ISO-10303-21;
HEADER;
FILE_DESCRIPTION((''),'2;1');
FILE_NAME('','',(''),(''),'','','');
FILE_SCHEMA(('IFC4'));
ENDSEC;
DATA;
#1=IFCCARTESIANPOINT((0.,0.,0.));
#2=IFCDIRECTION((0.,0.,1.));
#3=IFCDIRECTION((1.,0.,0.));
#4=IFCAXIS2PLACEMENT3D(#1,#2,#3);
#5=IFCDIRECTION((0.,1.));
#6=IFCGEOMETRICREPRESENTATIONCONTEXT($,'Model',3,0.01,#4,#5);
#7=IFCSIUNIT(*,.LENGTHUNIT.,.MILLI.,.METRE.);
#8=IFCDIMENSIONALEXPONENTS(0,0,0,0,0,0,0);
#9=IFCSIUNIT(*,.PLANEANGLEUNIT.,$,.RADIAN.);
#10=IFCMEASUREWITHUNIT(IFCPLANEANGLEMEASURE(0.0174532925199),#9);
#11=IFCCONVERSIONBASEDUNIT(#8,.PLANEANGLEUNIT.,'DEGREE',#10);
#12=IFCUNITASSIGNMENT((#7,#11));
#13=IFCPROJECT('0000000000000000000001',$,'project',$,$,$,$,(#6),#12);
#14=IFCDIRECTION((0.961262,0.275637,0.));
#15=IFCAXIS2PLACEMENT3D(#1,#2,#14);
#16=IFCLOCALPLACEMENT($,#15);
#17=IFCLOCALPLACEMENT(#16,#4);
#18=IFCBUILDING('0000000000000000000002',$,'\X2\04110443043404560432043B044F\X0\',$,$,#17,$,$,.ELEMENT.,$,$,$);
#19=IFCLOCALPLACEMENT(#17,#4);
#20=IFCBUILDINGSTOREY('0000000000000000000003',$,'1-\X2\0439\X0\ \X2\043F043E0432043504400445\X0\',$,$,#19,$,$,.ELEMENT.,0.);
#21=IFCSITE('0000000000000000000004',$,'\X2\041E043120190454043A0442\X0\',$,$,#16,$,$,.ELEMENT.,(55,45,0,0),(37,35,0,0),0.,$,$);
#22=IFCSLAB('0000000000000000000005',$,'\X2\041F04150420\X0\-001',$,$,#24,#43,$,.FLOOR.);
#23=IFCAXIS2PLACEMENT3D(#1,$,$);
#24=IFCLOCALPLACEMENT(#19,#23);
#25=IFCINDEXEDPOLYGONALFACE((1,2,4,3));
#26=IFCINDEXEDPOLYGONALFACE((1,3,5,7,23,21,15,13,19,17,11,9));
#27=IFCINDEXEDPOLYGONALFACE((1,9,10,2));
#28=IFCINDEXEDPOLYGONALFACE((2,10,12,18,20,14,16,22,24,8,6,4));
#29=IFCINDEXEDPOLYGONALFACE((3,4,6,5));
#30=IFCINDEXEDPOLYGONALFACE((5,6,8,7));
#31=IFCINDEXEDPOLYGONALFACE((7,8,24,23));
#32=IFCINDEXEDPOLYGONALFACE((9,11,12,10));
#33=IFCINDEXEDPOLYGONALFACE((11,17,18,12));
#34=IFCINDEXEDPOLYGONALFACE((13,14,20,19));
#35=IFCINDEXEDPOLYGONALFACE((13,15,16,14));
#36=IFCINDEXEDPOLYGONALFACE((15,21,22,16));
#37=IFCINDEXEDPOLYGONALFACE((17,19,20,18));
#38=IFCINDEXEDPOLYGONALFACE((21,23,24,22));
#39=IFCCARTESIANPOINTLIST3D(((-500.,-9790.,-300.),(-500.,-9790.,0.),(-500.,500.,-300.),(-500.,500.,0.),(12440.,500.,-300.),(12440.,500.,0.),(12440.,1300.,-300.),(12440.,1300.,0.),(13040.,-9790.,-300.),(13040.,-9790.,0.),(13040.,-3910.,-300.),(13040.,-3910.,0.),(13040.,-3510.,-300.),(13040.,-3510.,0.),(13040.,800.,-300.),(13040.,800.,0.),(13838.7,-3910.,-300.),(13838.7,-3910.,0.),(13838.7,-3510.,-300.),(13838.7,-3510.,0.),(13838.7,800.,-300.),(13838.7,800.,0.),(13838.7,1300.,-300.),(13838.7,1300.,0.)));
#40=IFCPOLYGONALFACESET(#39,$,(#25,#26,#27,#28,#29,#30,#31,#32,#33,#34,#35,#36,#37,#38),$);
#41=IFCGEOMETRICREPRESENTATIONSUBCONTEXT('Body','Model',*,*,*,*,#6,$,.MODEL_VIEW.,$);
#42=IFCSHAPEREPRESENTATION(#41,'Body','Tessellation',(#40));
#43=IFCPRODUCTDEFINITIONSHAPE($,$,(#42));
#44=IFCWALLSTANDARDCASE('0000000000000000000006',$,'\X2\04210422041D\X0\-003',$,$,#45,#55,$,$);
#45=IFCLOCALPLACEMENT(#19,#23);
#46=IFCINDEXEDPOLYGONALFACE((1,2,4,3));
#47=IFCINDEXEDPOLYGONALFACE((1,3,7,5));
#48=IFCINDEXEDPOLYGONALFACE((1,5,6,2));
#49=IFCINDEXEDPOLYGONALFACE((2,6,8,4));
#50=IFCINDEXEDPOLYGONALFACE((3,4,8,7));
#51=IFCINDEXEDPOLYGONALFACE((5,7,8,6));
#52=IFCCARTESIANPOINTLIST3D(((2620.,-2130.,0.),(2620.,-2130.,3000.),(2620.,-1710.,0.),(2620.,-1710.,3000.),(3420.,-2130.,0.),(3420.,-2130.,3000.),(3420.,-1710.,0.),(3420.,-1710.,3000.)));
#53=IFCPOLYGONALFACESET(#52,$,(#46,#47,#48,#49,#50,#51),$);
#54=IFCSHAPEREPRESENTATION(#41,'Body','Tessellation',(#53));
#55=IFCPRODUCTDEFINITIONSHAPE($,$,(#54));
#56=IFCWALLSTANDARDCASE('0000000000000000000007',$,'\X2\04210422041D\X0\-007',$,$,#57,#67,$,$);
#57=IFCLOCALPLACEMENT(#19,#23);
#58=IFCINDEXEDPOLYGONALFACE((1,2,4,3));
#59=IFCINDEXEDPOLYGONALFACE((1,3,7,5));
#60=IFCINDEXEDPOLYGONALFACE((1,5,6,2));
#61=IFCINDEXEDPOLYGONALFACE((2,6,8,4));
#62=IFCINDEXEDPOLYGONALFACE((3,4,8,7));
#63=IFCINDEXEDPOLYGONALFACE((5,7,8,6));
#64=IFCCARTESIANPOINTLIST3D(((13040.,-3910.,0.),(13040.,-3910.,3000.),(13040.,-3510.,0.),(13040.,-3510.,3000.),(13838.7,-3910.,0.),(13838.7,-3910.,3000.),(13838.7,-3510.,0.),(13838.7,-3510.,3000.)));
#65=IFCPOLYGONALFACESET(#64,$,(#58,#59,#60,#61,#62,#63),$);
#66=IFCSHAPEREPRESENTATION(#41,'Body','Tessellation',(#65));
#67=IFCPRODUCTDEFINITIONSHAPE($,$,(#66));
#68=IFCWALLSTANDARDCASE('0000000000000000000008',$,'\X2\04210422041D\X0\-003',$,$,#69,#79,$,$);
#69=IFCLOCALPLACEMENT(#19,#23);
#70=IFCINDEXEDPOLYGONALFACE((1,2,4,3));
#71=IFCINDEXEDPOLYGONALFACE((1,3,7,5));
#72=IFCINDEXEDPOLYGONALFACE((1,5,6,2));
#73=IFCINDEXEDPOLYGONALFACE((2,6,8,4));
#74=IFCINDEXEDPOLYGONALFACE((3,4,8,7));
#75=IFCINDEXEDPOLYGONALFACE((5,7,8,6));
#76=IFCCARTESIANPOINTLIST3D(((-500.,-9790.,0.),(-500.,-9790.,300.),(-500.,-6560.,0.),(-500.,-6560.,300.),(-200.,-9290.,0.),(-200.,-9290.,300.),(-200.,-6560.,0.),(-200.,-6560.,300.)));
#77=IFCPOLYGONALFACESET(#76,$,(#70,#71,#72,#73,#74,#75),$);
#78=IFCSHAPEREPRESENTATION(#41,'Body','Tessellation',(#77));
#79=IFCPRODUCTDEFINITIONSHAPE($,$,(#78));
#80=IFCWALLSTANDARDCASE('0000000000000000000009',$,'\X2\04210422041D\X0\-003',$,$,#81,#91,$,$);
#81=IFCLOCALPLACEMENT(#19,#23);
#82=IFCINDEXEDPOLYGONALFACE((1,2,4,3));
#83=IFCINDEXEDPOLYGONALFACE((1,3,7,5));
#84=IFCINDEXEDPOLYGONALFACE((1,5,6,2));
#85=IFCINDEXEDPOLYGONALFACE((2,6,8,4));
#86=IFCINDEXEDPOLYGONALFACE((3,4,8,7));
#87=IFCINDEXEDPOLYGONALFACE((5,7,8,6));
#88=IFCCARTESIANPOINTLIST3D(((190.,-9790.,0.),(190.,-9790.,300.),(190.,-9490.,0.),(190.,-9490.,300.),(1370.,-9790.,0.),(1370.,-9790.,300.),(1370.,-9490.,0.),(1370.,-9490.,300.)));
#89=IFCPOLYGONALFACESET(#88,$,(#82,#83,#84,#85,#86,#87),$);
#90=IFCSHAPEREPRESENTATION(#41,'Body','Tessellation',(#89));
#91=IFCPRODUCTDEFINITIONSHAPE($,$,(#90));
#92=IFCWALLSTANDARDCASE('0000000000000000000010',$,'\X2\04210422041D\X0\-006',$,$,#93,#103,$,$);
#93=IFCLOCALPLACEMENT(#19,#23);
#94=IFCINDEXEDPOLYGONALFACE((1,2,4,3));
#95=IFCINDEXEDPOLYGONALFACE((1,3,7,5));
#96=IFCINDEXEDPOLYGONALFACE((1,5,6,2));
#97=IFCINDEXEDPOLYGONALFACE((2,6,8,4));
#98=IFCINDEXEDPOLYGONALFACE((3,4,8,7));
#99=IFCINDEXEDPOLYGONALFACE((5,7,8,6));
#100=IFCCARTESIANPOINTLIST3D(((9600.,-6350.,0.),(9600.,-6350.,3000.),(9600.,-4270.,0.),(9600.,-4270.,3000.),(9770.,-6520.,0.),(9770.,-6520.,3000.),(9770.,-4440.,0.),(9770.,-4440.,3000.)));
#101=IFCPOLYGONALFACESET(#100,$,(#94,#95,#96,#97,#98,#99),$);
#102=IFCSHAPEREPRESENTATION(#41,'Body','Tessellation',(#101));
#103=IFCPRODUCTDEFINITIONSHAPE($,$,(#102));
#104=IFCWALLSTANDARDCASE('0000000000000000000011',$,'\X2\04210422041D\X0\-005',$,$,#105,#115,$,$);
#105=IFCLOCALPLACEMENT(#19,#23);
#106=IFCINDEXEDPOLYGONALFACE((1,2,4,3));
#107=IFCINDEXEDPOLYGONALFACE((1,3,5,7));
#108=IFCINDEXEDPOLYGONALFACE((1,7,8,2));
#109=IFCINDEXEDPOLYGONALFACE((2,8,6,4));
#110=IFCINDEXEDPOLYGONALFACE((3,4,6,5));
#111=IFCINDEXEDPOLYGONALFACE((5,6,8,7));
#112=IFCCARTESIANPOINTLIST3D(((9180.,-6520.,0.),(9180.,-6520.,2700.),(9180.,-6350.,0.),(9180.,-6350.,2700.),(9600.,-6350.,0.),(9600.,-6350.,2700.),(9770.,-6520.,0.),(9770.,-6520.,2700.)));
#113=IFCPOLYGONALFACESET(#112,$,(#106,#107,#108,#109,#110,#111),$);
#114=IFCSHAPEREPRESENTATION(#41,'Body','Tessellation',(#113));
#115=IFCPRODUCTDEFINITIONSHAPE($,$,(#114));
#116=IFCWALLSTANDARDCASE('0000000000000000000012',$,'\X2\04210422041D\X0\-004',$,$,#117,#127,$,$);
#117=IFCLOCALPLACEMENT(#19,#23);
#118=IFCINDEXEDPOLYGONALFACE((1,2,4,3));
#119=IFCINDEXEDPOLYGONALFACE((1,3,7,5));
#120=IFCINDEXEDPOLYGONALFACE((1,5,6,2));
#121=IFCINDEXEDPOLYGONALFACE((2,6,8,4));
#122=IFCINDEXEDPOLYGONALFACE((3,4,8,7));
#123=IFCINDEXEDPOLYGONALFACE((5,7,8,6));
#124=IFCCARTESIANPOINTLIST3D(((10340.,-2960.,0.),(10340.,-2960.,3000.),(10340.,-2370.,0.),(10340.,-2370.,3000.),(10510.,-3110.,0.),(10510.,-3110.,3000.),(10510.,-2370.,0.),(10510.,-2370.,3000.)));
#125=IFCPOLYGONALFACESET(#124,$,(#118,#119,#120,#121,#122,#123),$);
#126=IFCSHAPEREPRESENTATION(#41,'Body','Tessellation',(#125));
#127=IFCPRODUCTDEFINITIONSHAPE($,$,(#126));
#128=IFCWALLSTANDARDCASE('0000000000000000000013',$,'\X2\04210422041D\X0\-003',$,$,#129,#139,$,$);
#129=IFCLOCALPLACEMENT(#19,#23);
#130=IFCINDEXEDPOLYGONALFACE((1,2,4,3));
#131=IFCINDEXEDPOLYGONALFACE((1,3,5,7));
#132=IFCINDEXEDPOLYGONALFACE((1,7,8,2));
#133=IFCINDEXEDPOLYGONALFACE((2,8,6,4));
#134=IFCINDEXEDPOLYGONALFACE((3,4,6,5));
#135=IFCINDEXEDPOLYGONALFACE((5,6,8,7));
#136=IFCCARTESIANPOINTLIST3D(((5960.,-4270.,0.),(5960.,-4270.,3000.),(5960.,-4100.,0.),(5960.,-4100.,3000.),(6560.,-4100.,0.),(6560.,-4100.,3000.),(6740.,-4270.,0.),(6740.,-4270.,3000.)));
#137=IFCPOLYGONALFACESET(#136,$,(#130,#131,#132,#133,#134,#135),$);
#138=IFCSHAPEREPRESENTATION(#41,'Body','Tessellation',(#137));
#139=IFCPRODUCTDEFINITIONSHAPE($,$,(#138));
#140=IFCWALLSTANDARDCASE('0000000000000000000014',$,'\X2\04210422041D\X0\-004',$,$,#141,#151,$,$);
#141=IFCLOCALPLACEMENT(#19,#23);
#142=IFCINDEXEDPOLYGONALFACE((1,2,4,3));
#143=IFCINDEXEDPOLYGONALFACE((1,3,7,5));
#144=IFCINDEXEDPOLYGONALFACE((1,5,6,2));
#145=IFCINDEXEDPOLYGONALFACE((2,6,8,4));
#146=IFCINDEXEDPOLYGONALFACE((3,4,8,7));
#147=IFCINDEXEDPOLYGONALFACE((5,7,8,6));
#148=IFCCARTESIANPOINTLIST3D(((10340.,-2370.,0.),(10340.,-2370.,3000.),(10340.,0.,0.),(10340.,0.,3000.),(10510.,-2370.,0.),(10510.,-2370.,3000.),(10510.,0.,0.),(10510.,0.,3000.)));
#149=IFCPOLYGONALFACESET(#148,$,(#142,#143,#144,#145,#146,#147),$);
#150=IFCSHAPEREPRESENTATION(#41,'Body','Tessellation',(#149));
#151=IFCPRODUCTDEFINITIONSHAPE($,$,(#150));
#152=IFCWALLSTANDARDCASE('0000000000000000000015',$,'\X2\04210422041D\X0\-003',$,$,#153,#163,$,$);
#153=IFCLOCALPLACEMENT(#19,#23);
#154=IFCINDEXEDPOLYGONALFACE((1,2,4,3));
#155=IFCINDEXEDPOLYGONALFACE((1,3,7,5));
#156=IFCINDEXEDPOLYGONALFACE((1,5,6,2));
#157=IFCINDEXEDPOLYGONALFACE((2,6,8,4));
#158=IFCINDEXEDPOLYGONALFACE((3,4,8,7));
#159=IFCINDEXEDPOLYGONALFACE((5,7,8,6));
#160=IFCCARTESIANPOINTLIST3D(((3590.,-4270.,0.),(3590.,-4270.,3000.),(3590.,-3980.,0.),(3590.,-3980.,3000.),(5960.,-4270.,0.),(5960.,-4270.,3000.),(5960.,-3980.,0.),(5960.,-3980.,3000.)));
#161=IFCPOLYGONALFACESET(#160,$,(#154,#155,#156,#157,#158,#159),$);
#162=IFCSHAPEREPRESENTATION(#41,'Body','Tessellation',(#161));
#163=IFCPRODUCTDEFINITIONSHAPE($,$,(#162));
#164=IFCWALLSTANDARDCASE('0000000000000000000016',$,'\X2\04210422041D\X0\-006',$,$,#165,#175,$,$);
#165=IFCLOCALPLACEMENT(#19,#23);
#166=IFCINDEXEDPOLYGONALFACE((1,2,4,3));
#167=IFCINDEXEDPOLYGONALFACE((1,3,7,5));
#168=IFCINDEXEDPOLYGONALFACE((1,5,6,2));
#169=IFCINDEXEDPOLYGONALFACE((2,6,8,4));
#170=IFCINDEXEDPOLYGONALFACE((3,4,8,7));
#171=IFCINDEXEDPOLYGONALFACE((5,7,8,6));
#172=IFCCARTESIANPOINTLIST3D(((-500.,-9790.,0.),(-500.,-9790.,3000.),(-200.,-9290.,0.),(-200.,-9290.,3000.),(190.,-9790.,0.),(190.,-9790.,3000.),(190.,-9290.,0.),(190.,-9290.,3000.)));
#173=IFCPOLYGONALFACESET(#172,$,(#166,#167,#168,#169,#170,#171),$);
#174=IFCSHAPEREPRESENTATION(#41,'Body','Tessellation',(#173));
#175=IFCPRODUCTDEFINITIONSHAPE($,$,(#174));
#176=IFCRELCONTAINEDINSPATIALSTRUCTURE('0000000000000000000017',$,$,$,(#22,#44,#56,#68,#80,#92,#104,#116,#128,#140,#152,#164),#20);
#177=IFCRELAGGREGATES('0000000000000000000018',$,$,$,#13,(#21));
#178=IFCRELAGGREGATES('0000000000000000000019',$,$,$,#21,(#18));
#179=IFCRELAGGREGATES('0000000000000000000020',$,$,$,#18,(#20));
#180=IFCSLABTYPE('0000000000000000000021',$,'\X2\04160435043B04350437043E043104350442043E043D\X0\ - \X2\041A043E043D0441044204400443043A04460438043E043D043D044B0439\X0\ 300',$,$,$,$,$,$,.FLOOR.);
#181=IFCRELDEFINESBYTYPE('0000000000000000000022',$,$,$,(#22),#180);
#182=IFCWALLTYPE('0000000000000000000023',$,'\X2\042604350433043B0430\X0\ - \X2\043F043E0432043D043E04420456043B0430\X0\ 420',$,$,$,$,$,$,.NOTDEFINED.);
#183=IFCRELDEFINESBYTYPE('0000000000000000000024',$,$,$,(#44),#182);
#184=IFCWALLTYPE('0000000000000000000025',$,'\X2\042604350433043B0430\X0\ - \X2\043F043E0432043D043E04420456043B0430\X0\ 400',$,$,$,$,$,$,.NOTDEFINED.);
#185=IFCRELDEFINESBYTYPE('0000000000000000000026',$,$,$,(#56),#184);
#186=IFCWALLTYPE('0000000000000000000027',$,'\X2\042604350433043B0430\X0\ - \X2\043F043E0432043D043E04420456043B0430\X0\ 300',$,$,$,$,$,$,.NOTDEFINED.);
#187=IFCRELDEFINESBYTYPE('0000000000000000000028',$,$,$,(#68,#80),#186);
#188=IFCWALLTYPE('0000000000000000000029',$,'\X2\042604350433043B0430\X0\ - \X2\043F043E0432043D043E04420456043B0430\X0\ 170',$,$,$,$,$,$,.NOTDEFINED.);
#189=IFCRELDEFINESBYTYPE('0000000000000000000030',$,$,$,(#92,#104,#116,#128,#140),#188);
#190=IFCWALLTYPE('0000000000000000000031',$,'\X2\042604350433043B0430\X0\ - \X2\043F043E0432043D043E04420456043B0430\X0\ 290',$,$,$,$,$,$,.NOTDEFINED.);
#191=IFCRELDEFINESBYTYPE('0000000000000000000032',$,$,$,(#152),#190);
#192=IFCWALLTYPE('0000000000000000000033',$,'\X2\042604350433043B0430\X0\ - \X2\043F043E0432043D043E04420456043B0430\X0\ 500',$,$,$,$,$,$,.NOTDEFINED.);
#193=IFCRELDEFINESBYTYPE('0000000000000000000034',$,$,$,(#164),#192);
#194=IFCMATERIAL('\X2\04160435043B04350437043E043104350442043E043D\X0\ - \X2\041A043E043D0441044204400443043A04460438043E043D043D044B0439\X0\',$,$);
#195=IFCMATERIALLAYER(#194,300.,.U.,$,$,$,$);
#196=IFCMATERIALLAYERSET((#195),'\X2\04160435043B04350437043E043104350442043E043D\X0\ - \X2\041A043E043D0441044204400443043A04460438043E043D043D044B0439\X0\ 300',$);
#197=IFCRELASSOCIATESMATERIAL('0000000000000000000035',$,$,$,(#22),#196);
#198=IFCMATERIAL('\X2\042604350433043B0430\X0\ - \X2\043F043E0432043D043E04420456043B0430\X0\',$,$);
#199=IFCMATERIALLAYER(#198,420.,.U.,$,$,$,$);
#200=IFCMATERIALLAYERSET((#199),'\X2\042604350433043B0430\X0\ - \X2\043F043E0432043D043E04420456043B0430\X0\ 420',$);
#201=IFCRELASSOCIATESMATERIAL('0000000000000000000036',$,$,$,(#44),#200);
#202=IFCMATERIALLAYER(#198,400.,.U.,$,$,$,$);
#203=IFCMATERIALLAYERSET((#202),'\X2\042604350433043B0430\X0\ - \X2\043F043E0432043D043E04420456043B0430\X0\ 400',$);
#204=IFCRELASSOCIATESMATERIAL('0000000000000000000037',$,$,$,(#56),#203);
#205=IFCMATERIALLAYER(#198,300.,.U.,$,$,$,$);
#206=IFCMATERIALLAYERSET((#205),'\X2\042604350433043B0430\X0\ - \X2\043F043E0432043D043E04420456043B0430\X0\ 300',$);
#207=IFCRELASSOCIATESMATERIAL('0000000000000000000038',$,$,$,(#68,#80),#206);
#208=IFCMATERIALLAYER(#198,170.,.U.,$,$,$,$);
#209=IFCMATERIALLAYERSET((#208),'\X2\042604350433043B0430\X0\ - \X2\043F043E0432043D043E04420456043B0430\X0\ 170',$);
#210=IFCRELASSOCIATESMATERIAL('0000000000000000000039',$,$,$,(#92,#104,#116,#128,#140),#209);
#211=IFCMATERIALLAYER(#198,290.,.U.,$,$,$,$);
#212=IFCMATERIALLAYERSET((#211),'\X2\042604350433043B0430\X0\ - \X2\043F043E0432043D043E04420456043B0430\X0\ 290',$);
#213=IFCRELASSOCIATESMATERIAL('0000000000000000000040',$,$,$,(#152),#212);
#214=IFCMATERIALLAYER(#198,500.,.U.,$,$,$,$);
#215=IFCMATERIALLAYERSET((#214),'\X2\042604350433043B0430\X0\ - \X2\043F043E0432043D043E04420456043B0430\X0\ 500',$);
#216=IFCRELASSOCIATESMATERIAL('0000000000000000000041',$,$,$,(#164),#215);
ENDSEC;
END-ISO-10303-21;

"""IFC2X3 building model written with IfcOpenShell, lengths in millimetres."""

from ifc_helpers import new_model, entity, si_unit, converted_unit, direction, frame, origin_with_axes, place, context, subcontext, project, spatial, polyline, outline, extrude, material, layer, layer_set, layer_usage, type_object, element, save


model = new_model("IFC2X3")

# Units and contexts
model_context = context("Model", 3, precision=0.01, world=origin_with_axes(), true_north=direction((0.0, 1.0)))
body_context = subcontext(model_context, "Body", "Model", "MODEL_VIEW")
ifc_project = project(units=[si_unit("LENGTHUNIT", "METRE", prefix="MILLI"), converted_unit("PLANEANGLEUNIT", "DEGREE", entity("IfcPlaneAngleMeasure", 0.0174532925199), si_unit("PLANEANGLEUNIT", "RADIAN"), dimensions=[0, 0, 0, 0, 0, 0, 0])], contexts=[model_context])

# Site, building, storey
site_placement = place(None, frame((0.0, 0.0, 0.0), z_axis=(0.0, 0.0, 1.0), x_axis=(0.961262, 0.275637, 0.0)))
site = spatial("IfcSite", under=ifc_project, at=site_placement, Name="Об’єкт", CompositionType="ELEMENT", RefLatitude=(55, 45, 0, 0), RefLongitude=(37, 35, 0, 0), RefElevation=0.0)
building_placement = place(site_placement, origin_with_axes())
building = spatial("IfcBuilding", under=site, at=building_placement, Name="Будівля", CompositionType="ELEMENT")
storey_placement = place(building_placement, origin_with_axes())
storey = spatial("IfcBuildingStorey", under=building, at=storey_placement, Name="1-й поверх", CompositionType="ELEMENT", Elevation=0.0)

# Slab
ifc_material_1 = material(Name="Железобетон - Конструкционный")
ifc_layer_1 = layer(ifc_material_1, 300.0, ventilated="UNKNOWN")
ifc_layer_set_1 = layer_set([ifc_layer_1], Name="Железобетон - Конструкционный 300")
ifc_layer_usage_1 = layer_usage(ifc_layer_set_1, "AXIS3", "NEGATIVE", 300.0)
slab_type = type_object("IfcSlabType", Name="Железобетон - Конструкционный 300", PredefinedType="FLOOR")
slab_placement = place(storey_placement, frame((-500.0, 500.0, 0.0), z_axis=(0.0, 0.0, 1.0), x_axis=(1.0, 0.0, 0.0)))
element("IfcSlab", 1, at=slab_placement, inside=storey, type_object=slab_type, material=ifc_layer_usage_1, Name="ПЕР-001", PredefinedType="FLOOR", context=body_context, shape_type="SweptSolid", body=[
    extrude(outline(polyline([(0.0, 0.0), (0.0, -10290.0), (13540.0, -10290.0), (13540.0, -4410.0), (14338.7, -4410.0), (14338.7, -4010.0), (13540.0, -4010.0), (13540.0, 300.0), (14338.7, 300.0), (14338.7, 800.0), (12940.0, 800.0), (12940.0, 0.0), (0.0, 0.0)])), frame((0.0, 0.0, -300.0), z_axis=(0.0, 0.0, 1.0), x_axis=(1.0, 0.0, 0.0)), (0.0, 0.0, 1.0), 300.0),
])

# Walls
ifc_material_2 = material(Name="Цегла - повнотіла")
ifc_layer_2 = layer(ifc_material_2, 420.0, ventilated="UNKNOWN")
ifc_layer_set_2 = layer_set([ifc_layer_2], Name="Цегла - повнотіла 420")
ifc_layer_usage_2 = layer_usage(ifc_layer_set_2, "AXIS2", "POSITIVE", 0.0)
wall_type_1 = type_object("IfcWallType", Name="Цегла - повнотіла 420", PredefinedType="NOTDEFINED")
wall_1_placement = place(storey_placement, frame((2620.0, -2130.0, 0.0), z_axis=(0.0, 0.0, 1.0), x_axis=(1.0, 0.0, 0.0)))
element("IfcWallStandardCase", 2, at=wall_1_placement, inside=storey, type_object=wall_type_1, material=ifc_layer_usage_2, Name="СТН-003", context=body_context, shape_type="SweptSolid", body=[
    extrude(outline(polyline([(0.0, 0.0), (800.0, 0.0), (800.0, 420.0), (0.0, 420.0), (0.0, 0.0)])), origin_with_axes(), (0.0, 0.0, 1.0), 3000.0),
])
ifc_layer_3 = layer(ifc_material_2, 400.0, ventilated="UNKNOWN")
ifc_layer_set_3 = layer_set([ifc_layer_3], Name="Цегла - повнотіла 400")
ifc_layer_usage_3 = layer_usage(ifc_layer_set_3, "AXIS2", "POSITIVE", -400.0)
wall_type_2 = type_object("IfcWallType", Name="Цегла - повнотіла 400", PredefinedType="NOTDEFINED")
wall_2_placement = place(storey_placement, frame((13040.0, -3510.0, 0.0), z_axis=(0.0, 0.0, 1.0), x_axis=(1.0, 0.0, 0.0)))
element("IfcWallStandardCase", 3, at=wall_2_placement, inside=storey, type_object=wall_type_2, material=ifc_layer_usage_3, Name="СТН-007", context=body_context, shape_type="SweptSolid", body=[
    extrude(outline(polyline([(0.0, -400.0), (798.7, -400.0), (798.7, 0.0), (0.0, 0.0), (0.0, -400.0)])), origin_with_axes(), (0.0, 0.0, 1.0), 3000.0),
])
ifc_layer_4 = layer(ifc_material_2, 300.0, ventilated="UNKNOWN")
ifc_layer_set_4 = layer_set([ifc_layer_4], Name="Цегла - повнотіла 300")
ifc_layer_usage_4 = layer_usage(ifc_layer_set_4, "AXIS2", "POSITIVE", -300.0)
wall_type_3 = type_object("IfcWallType", Name="Цегла - повнотіла 300", PredefinedType="NOTDEFINED")
wall_3_placement = place(storey_placement, frame((-500.0, -9790.0, 0.0), z_axis=(0.0, 0.0, 1.0), x_axis=(0.0, 1.0, 0.0)))
element("IfcWallStandardCase", 4, at=wall_3_placement, inside=storey, type_object=wall_type_3, material=ifc_layer_usage_4, Name="СТН-003", context=body_context, shape_type="SweptSolid", body=[
    extrude(outline(polyline([(500.0, -300.0), (3230.0, -300.0), (3230.0, 0.0), (0.0, 0.0), (500.0, -300.0)])), origin_with_axes(), (0.0, 0.0, 1.0), 300.0),
])
ifc_layer_usage_5 = layer_usage(ifc_layer_set_4, "AXIS2", "POSITIVE", 0.0)
wall_4_placement = place(storey_placement, frame((190.0, -9790.0, 0.0), z_axis=(0.0, 0.0, 1.0), x_axis=(1.0, 0.0, 0.0)))
element("IfcWallStandardCase", 5, at=wall_4_placement, inside=storey, type_object=wall_type_3, material=ifc_layer_usage_5, Name="СТН-003", context=body_context, shape_type="SweptSolid", body=[
    extrude(outline(polyline([(0.0, 0.0), (1180.0, 0.0), (1180.0, 300.0), (0.0, 300.0), (0.0, 0.0)])), origin_with_axes(), (0.0, 0.0, 1.0), 300.0),
])
ifc_layer_5 = layer(ifc_material_2, 170.0, ventilated="UNKNOWN")
ifc_layer_set_5 = layer_set([ifc_layer_5], Name="Цегла - повнотіла 170")
ifc_layer_usage_6 = layer_usage(ifc_layer_set_5, "AXIS2", "POSITIVE", -170.0)
wall_type_4 = type_object("IfcWallType", Name="Цегла - повнотіла 170", PredefinedType="NOTDEFINED")
wall_5_placement = place(storey_placement, frame((9600.0, -6520.0, 0.0), z_axis=(0.0, 0.0, 1.0), x_axis=(0.0, 1.0, 0.0)))
element("IfcWallStandardCase", 6, at=wall_5_placement, inside=storey, type_object=wall_type_4, material=ifc_layer_usage_6, Name="СТН-006", context=body_context, shape_type="SweptSolid", body=[
    extrude(outline(polyline([(0.0, -170.0), (2080.0, -170.0), (2250.0, 0.0), (170.0, 0.0), (0.0, -170.0)])), origin_with_axes(), (0.0, 0.0, 1.0), 3000.0),
])
ifc_layer_usage_7 = layer_usage(ifc_layer_set_5, "AXIS2", "POSITIVE", 0.0)
wall_6_placement = place(storey_placement, frame((9180.0, -6520.0, 0.0), z_axis=(0.0, 0.0, 1.0), x_axis=(1.0, 0.0, 0.0)))
element("IfcWallStandardCase", 7, at=wall_6_placement, inside=storey, type_object=wall_type_4, material=ifc_layer_usage_7, Name="СТН-005", context=body_context, shape_type="SweptSolid", body=[
    extrude(outline(polyline([(0.0, 0.0), (590.0, 0.0), (420.0, 170.0), (0.0, 170.0), (0.0, 0.0)])), origin_with_axes(), (0.0, 0.0, 1.0), 2700.0),
])
ifc_layer_usage_8 = layer_usage(ifc_layer_set_5, "AXIS2", "POSITIVE", 0.0)
wall_7_placement = place(storey_placement, frame((10510.0, -3110.0, 0.0), z_axis=(0.0, 0.0, 1.0), x_axis=(0.0, 1.0, 0.0)))
element("IfcWallStandardCase", 8, at=wall_7_placement, inside=storey, type_object=wall_type_4, material=ifc_layer_usage_8, Name="СТН-004", context=body_context, shape_type="SweptSolid", body=[
    extrude(outline(polyline([(0.0, 0.0), (740.0, 0.0), (740.0, 170.0), (150.0, 170.0), (0.0, 0.0)])), origin_with_axes(), (0.0, 0.0, 1.0), 3000.0),
])
ifc_layer_usage_9 = layer_usage(ifc_layer_set_5, "AXIS2", "POSITIVE", 0.0)
wall_8_placement = place(storey_placement, frame((5960.0, -4270.0, 0.0), z_axis=(0.0, 0.0, 1.0), x_axis=(1.0, 0.0, 0.0)))
element("IfcWallStandardCase", 9, at=wall_8_placement, inside=storey, type_object=wall_type_4, material=ifc_layer_usage_9, Name="СТН-003", context=body_context, shape_type="SweptSolid", body=[
    extrude(outline(polyline([(0.0, 0.0), (780.0, 0.0), (600.0, 170.0), (0.0, 170.0), (0.0, 0.0)])), origin_with_axes(), (0.0, 0.0, 1.0), 3000.0),
])
ifc_layer_usage_10 = layer_usage(ifc_layer_set_5, "AXIS2", "POSITIVE", 0.0)
wall_9_placement = place(storey_placement, frame((10510.0, -2370.0, 0.0), z_axis=(0.0, 0.0, 1.0), x_axis=(0.0, 1.0, 0.0)))
element("IfcWallStandardCase", 10, at=wall_9_placement, inside=storey, type_object=wall_type_4, material=ifc_layer_usage_10, Name="СТН-004", context=body_context, shape_type="SweptSolid", body=[
    extrude(outline(polyline([(0.0, 0.0), (2370.0, 0.0), (2370.0, 170.0), (0.0, 170.0), (0.0, 0.0)])), origin_with_axes(), (0.0, 0.0, 1.0), 3000.0),
])
ifc_layer_6 = layer(ifc_material_2, 290.0, ventilated="UNKNOWN")
ifc_layer_set_6 = layer_set([ifc_layer_6], Name="Цегла - повнотіла 290")
ifc_layer_usage_11 = layer_usage(ifc_layer_set_6, "AXIS2", "POSITIVE", 0.0)
wall_type_5 = type_object("IfcWallType", Name="Цегла - повнотіла 290", PredefinedType="NOTDEFINED")
wall_10_placement = place(storey_placement, frame((3590.0, -4270.0, 0.0), z_axis=(0.0, 0.0, 1.0), x_axis=(1.0, 0.0, 0.0)))
element("IfcWallStandardCase", 11, at=wall_10_placement, inside=storey, type_object=wall_type_5, material=ifc_layer_usage_11, Name="СТН-003", context=body_context, shape_type="SweptSolid", body=[
    extrude(outline(polyline([(0.0, 0.0), (2370.0, 0.0), (2370.0, 290.0), (0.0, 290.0), (0.0, 0.0)])), origin_with_axes(), (0.0, 0.0, 1.0), 3000.0),
])
ifc_layer_7 = layer(ifc_material_2, 500.0, ventilated="UNKNOWN")
ifc_layer_set_7 = layer_set([ifc_layer_7], Name="Цегла - повнотіла 500")
ifc_layer_usage_12 = layer_usage(ifc_layer_set_7, "AXIS2", "POSITIVE", 0.0)
wall_type_6 = type_object("IfcWallType", Name="Цегла - повнотіла 500", PredefinedType="NOTDEFINED")
wall_11_placement = place(storey_placement, frame((-500.0, -9790.0, 0.0), z_axis=(0.0, 0.0, 1.0), x_axis=(1.0, 0.0, 0.0)))
element("IfcWallStandardCase", 12, at=wall_11_placement, inside=storey, type_object=wall_type_6, material=ifc_layer_usage_12, Name="СТН-006", context=body_context, shape_type="SweptSolid", body=[
    extrude(outline(polyline([(0.0, 0.0), (690.0, 0.0), (690.0, 500.0), (300.0, 500.0), (0.0, 0.0)])), origin_with_axes(), (0.0, 0.0, 1.0), 3000.0),
])

save(model, "model.ifc")
